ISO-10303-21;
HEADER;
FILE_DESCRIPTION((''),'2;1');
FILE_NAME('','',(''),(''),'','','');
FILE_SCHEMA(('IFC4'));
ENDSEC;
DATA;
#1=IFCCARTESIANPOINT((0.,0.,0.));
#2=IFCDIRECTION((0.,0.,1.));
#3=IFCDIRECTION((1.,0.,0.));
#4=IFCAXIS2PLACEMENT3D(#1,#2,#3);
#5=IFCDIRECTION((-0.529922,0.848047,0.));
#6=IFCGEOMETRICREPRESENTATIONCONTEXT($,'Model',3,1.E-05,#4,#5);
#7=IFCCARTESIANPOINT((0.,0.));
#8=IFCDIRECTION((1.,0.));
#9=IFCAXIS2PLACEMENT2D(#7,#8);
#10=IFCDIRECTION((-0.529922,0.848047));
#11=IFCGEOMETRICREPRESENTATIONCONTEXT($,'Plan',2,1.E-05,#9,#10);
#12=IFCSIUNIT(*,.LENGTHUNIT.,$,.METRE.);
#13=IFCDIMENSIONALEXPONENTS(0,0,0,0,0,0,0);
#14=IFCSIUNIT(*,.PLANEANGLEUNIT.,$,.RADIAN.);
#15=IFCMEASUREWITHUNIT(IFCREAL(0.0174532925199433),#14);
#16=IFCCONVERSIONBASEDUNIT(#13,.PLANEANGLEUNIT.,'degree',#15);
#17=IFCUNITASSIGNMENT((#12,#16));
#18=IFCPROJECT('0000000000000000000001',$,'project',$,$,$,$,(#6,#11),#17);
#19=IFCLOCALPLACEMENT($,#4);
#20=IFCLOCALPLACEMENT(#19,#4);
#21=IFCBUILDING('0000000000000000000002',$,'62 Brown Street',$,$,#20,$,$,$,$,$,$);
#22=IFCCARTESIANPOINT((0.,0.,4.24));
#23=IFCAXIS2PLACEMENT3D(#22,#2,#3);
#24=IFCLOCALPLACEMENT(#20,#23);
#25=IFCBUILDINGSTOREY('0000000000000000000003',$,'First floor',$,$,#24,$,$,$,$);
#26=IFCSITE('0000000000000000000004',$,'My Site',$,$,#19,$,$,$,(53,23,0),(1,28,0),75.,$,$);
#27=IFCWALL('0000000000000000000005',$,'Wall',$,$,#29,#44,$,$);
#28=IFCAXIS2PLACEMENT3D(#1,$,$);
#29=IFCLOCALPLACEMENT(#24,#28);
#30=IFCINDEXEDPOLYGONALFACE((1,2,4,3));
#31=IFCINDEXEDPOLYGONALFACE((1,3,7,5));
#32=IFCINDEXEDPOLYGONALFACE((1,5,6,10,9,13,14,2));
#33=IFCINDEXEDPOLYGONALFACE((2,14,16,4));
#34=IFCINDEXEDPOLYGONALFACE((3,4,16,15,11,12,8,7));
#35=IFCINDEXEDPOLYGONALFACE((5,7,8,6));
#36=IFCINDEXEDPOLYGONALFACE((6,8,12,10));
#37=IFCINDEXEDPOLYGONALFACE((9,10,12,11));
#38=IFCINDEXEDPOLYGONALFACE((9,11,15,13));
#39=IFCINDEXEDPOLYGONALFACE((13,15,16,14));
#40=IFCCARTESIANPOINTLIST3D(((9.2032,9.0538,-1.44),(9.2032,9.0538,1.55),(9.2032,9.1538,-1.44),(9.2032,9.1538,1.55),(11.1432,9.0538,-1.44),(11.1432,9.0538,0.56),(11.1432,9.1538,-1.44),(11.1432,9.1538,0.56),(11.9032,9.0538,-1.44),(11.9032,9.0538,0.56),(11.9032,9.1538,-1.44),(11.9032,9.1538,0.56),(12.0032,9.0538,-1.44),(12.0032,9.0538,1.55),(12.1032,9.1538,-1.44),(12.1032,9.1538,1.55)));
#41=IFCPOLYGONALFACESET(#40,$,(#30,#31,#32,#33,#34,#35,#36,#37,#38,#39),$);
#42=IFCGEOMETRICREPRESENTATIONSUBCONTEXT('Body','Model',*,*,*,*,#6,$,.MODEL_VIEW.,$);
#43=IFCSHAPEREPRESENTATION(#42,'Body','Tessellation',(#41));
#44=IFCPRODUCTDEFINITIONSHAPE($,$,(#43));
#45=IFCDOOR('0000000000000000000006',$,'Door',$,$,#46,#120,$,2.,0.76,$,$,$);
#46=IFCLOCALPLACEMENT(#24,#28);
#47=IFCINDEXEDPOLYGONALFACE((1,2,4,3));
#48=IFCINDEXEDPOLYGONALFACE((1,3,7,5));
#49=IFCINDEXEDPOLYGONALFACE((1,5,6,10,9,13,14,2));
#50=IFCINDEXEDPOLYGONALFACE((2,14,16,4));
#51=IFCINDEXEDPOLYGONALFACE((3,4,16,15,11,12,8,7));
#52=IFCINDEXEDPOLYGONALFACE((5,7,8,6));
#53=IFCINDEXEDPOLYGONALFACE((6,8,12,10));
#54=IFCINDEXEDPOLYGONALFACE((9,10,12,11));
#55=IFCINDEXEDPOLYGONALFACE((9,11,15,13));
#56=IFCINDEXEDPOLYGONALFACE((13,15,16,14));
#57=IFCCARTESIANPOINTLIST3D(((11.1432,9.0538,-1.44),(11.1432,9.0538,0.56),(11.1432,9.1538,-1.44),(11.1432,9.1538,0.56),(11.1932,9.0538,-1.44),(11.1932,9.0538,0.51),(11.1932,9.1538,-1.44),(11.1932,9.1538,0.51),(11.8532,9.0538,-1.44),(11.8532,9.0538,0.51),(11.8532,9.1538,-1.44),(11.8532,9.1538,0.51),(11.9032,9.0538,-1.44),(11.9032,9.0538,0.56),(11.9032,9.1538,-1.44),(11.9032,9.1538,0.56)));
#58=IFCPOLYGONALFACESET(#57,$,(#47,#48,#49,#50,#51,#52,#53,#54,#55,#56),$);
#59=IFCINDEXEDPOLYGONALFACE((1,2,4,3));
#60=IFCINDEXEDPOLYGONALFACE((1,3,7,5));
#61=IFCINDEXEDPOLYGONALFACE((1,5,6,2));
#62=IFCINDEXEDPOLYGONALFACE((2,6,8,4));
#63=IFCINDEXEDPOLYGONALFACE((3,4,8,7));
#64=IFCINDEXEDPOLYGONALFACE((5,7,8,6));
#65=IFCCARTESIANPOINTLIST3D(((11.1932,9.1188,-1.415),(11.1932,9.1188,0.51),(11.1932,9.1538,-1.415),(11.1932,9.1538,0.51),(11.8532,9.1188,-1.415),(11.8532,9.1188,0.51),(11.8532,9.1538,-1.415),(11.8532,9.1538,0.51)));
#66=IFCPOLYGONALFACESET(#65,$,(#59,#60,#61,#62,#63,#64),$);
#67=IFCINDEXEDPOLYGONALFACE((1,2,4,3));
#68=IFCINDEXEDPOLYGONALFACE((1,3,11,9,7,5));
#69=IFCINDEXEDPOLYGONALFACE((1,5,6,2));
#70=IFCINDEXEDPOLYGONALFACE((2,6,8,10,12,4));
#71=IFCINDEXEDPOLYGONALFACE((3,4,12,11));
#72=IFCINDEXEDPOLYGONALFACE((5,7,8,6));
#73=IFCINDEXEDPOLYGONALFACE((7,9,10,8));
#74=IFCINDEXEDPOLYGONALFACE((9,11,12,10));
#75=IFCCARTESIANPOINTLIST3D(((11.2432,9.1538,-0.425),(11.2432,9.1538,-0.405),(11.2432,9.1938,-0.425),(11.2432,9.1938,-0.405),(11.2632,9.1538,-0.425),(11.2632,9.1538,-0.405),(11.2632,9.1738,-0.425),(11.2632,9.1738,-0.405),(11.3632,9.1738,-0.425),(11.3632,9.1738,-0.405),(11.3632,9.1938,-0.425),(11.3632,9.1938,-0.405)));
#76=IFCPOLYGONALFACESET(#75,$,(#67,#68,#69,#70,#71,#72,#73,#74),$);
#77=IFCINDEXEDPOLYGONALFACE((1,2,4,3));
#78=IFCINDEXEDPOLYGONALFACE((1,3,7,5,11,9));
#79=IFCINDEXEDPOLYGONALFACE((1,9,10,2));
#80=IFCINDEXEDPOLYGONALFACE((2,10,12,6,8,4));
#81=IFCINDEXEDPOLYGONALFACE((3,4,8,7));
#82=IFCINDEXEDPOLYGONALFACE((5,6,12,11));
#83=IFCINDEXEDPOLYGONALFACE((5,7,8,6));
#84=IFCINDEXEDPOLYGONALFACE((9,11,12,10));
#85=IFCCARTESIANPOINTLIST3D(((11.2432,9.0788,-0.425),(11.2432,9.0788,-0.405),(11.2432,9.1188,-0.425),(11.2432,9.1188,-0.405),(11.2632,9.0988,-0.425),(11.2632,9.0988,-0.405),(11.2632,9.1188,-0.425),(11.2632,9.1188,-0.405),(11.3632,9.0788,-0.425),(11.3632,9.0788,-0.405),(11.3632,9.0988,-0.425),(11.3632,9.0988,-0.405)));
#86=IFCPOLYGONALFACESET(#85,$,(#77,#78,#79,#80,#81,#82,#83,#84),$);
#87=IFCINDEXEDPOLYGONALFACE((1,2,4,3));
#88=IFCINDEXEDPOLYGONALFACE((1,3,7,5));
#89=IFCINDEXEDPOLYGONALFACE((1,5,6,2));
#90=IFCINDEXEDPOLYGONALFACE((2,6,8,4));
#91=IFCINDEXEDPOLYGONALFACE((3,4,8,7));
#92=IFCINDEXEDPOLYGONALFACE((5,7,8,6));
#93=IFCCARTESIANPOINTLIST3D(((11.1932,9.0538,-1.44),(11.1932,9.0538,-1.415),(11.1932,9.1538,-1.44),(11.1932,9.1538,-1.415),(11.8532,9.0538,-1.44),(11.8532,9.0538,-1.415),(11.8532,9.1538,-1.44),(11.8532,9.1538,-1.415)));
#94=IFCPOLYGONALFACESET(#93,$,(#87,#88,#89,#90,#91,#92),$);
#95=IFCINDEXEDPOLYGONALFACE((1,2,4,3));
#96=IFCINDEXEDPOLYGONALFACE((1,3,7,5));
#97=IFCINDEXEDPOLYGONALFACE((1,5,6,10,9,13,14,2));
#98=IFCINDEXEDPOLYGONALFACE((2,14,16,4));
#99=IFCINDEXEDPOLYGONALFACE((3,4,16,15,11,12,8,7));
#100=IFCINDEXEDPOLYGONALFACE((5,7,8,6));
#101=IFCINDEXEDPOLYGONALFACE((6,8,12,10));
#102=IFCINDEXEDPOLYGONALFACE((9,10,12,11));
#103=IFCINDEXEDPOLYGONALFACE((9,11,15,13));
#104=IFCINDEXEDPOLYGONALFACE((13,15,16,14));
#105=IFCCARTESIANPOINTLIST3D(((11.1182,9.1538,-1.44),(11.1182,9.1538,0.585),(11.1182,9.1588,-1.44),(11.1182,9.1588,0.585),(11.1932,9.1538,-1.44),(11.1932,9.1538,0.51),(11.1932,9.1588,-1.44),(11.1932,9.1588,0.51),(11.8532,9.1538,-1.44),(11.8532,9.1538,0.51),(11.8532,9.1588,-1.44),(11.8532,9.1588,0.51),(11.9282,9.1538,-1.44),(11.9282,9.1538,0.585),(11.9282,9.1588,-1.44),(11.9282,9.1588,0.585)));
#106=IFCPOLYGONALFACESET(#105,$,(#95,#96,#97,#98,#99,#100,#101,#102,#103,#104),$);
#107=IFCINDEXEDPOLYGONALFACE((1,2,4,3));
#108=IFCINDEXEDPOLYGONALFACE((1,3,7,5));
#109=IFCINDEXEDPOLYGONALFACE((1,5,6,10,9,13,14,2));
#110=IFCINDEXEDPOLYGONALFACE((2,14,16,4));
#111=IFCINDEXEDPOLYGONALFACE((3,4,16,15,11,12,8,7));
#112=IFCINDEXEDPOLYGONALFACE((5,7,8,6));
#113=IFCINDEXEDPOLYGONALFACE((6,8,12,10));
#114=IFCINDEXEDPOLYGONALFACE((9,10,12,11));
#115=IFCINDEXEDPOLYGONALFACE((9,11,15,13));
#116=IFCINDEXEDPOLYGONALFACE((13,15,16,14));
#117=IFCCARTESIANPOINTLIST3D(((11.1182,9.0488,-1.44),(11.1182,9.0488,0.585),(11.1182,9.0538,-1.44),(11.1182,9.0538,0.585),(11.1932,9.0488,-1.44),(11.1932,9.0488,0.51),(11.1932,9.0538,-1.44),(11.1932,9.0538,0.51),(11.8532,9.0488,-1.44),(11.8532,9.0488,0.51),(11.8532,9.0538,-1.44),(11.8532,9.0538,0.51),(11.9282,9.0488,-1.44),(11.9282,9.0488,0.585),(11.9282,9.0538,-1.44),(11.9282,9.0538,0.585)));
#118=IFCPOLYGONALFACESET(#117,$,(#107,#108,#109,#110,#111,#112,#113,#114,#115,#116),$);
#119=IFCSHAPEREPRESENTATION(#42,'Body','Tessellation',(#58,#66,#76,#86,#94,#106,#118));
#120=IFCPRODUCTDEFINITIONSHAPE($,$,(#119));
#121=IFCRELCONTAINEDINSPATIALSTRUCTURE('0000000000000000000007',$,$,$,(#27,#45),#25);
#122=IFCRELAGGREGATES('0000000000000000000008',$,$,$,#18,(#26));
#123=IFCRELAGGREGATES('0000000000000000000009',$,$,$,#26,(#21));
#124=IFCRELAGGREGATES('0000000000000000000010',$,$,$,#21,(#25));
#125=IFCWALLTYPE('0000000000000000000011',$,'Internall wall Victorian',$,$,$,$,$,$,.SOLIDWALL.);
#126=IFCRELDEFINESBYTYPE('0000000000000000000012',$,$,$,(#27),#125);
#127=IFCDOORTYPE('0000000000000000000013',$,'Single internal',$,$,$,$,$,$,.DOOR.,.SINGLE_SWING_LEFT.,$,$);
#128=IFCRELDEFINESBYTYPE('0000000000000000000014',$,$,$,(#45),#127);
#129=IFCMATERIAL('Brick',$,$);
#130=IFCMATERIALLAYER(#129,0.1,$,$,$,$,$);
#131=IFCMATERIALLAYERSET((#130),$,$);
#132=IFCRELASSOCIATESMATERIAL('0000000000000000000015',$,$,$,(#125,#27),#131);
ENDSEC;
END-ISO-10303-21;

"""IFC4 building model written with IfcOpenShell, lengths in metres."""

from ifc_helpers import new_model, entity, si_unit, converted_unit, direction, frame, origin_with_axes, origin_2d_with_axis, place, context, subcontext, project, spatial, line, indexed_curve, outline, extrude, clip, halfspace, shape, source, transform, mapped, material, layer, layer_set, layer_usage, type_object, type_shapes, element, fill, save


model = new_model("IFC4")

# Units and contexts
model_context = context("Model", 3, precision=1e-05, world=origin_with_axes(), true_north=direction((-0.529922, 0.848047, 0.0)))
plan_context = context("Plan", 2, precision=1e-05, world=origin_2d_with_axis(), true_north=direction((-0.529922, 0.848047)))
body_context_1 = subcontext(model_context, "Body", "Model", "MODEL_VIEW")
body_context_2 = subcontext(plan_context, "Body", "Plan", "PLAN_VIEW")
ifc_project = project(units=[si_unit("LENGTHUNIT", "METRE"), converted_unit("PLANEANGLEUNIT", "degree", entity("IfcReal", 0.0174532925199433), si_unit("PLANEANGLEUNIT", "RADIAN"), dimensions=[0, 0, 0, 0, 0, 0, 0])], contexts=[model_context, plan_context])

# Site, building, storey
site_placement = place(None, origin_with_axes())
site = spatial("IfcSite", under=ifc_project, at=site_placement, Name="My Site", RefLatitude=(53, 23, 0), RefLongitude=(1, 28, 0), RefElevation=75.0)
building_placement = place(site_placement, origin_with_axes())
building = spatial("IfcBuilding", under=site, at=building_placement, Name="62 Brown Street")
storey_placement = place(building_placement, frame((0.0, 0.0, 4.24), z_axis=(0.0, 0.0, 1.0), x_axis=(1.0, 0.0, 0.0)))
storey = spatial("IfcBuildingStorey", under=building, at=storey_placement, Name="First floor")

# Shared definitions
ifc_material_1 = material(Name="Brick")

# Shared definitions
ifc_layer_1 = layer(ifc_material_1, 0.1)
ifc_layer_set_1 = layer_set([ifc_layer_1])
wall_type_1 = type_object("IfcWallType", Name="Internall wall Victorian", PredefinedType="SOLIDWALL", material=ifc_layer_set_1)

# Wall, opening, door
ifc_layer_usage_1 = layer_usage(ifc_layer_set_1, "AXIS2", "POSITIVE", 0.0)
wall_1_placement = place(storey_placement, frame((12.1032, 9.1538, -1.44), z_axis=(0.0, 0.0, 1.0), x_axis=(-1.0, 0.0, 0.0)))
wall_1 = element("IfcWall", 1, at=wall_1_placement, inside=storey, type_object=wall_type_1, material=ifc_layer_usage_1, Name="Wall", context=body_context_1, shape_type="Clipping", body=[
    clip(extrude(outline(indexed_curve([(0.0, 0.0), (0.0, 0.1), (2.9, 0.1), (2.9, 0.0), (0.0, 0.0)], self_intersect=False)), origin_with_axes(), (0.0, 0.0, 1.0), 2.99), halfspace(frame((0.0, 0.0, -2.8), z_axis=(-0.299001, 0.299001, 0.0), x_axis=(0.1, 0.1, 0.0)), False)),
])
shared_shape_1 = source(origin_with_axes(), body_context_1, "Body", "SweptSolid", [
    extrude(outline(indexed_curve([(0.0, 0.0), (0.76, 0.0), (0.76, 2.0), (0.0, 2.0)], segments=[line(1, 2, 3, 4, 1)])), frame((0.0, -0.6, 0.0), z_axis=(0.0, -1.0, 0.0), x_axis=(1.0, 0.0, 0.0)), (0.0, 0.0, -1.0), 1.2),
])
opening_1_placement = place(wall_1_placement, frame((0.2, 0.0, 0.0), z_axis=(0.0, 0.0, 1.0), x_axis=(1.0, 0.0, 0.0)))
opening_1 = element("IfcOpeningElement", 2, at=opening_1_placement, cuts=wall_1, PredefinedType="OPENING", context=body_context_1, shape_type="MappedRepresentation", body=[
    mapped(shared_shape_1, transform((0.0, 0.0, 0.0), x_axis=(1.0, 0.0, 0.0), y_axis=(0.0, 1.0, 0.0), z_axis=(0.0, 0.0, 1.0), scale=1.0)),
])
door_type = type_object("IfcDoorType", Name="Single internal", OperationType="SINGLE_SWING_LEFT", PredefinedType="DOOR")
shared_shape_2 = source(origin_with_axes(), body_context_1, "Body", "SweptSolid", [
    extrude(outline(indexed_curve([(0.0, 0.0), (0.0, 2.0), (0.76, 2.0), (0.76, 0.0), (0.71, 0.0), (0.71, 1.95), (0.05, 1.95), (0.05, 0.0)], segments=[line(1, 2, 3, 4, 5, 6, 7, 8, 1)])), frame((0.0, 0.0, 0.0), z_axis=(0.0, -1.0, 0.0), x_axis=(1.0, 0.0, 0.0)), (0.0, 0.0, -1.0), 0.1),
    extrude(outline(indexed_curve([(0.0, 0.0), (0.66, 0.0), (0.66, 0.035), (0.0, 0.035)], segments=[line(1, 2, 3, 4, 1)])), frame((0.05, 0.0, 0.025), z_axis=(0.0, 0.0, 1.0), x_axis=(1.0, 0.0, 0.0)), (0.0, 0.0, 1.0), 1.925),
    extrude(outline(indexed_curve([(0.0, 0.0), (0.0, -0.04), (-0.12, -0.04), (-0.12, -0.02), (-0.02, -0.02), (-0.02, 0.0)], segments=[line(1, 2, 3, 4, 5, 6, 1)])), frame((0.66, 0.0, 1.015), z_axis=(0.0, 0.0, 1.0), x_axis=(1.0, 0.0, 0.0)), (0.0, 0.0, 1.0), 0.02),
    extrude(outline(indexed_curve([(0.0, 0.0), (0.0, 0.04), (-0.12, 0.04), (-0.12, 0.02), (-0.02, 0.02), (-0.02, 0.0)], segments=[line(1, 2, 3, 4, 5, 6, 1)])), frame((0.66, 0.035, 1.015), z_axis=(0.0, 0.0, 1.0), x_axis=(1.0, 0.0, 0.0)), (0.0, 0.0, 1.0), 0.02),
    extrude(outline(indexed_curve([(0.0, 0.0), (0.66, 0.0), (0.66, 0.1), (0.0, 0.1)], segments=[line(1, 2, 3, 4, 1)])), frame((0.05, 0.0, 0.0), z_axis=(0.0, 0.0, 1.0), x_axis=(1.0, 0.0, 0.0)), (0.0, 0.0, 1.0), 0.025),
    extrude(outline(indexed_curve([(0.0, 0.0), (0.0, 2.025), (0.81, 2.025), (0.81, 0.0), (0.735, 0.0), (0.735, 1.95), (0.075, 1.95), (0.075, 0.0)], segments=[line(1, 2, 3, 4, 5, 6, 7, 8, 1)])), frame((-0.025, -0.005, 0.0), z_axis=(0.0, -1.0, 0.0), x_axis=(1.0, 0.0, 0.0)), (0.0, 0.0, -1.0), 0.005),
    extrude(outline(indexed_curve([(0.0, 0.0), (0.0, 2.025), (0.81, 2.025), (0.81, 0.0), (0.735, 0.0), (0.735, 1.95), (0.075, 1.95), (0.075, 0.0)], segments=[line(1, 2, 3, 4, 5, 6, 7, 8, 1)])), frame((-0.025, 0.1, 0.0), z_axis=(0.0, -1.0, 0.0), x_axis=(1.0, 0.0, 0.0)), (0.0, 0.0, -1.0), 0.005),
])
shared_shape_3 = source(origin_with_axes(), body_context_2, "Body", "Curve2D", [
    entity("IfcIndexedPolyCurve", entity("IfcCartesianPointList2D", [[0.0, 0.0], [0.05, 0.0], [0.05, 0.1], [0.0, 0.1]]), [entity("IfcLineIndex", [1, 2, 3, 4, 1])]),
    entity("IfcIndexedPolyCurve", entity("IfcCartesianPointList2D", [[0.76, 0.0], [0.71, 0.0], [0.71, 0.1], [0.76, 0.1]]), [entity("IfcLineIndex", [1, 2, 3, 4, 1])]),
    entity("IfcTrimmedCurve", entity("IfcEllipse", entity("IfcAxis2Placement2D", entity("IfcCartesianPoint", [0.085, 0.1]), entity("IfcDirection", [1.0, 0.0])), 0.625, 0.66), [entity("IfcCartesianPoint", [0.71, 0.1])], [entity("IfcCartesianPoint", [0.085, 0.76])], True, "CARTESIAN"),
    entity("IfcIndexedPolyCurve", entity("IfcCartesianPointList2D", [[0.05, 0.1], [0.085, 0.1], [0.085, 0.76], [0.05, 0.76]]), [entity("IfcLineIndex", [1, 2, 3, 4, 1])]),
])
type_shapes(door_type, [shared_shape_2, shared_shape_3])
door_placement = place(opening_1_placement, frame((0.0, 0.0, 0.0), z_axis=(0.0, 0.0, 1.0), x_axis=(1.0, 0.0, 0.0)))
door = element("IfcDoor", 3, at=door_placement, inside=storey, type_object=door_type, Name="Door", OverallHeight=2.0, OverallWidth=0.76, shapes=[
    shape(body_context_1, "Body", "MappedRepresentation", [mapped(shared_shape_2, transform((0.0, 0.0, 0.0), x_axis=(1.0, 0.0, 0.0), y_axis=(0.0, 1.0, 0.0), z_axis=(0.0, 0.0, 1.0), scale=1.0))]),
    shape(body_context_2, "Body", "MappedRepresentation", [mapped(shared_shape_3, transform((0.0, 0.0, 0.0), x_axis=(1.0, 0.0, 0.0), y_axis=(0.0, 1.0, 0.0), z_axis=(0.0, 0.0, 1.0), scale=1.0))]),
])
fill(opening_1, door)

save(model, "model.ifc")
